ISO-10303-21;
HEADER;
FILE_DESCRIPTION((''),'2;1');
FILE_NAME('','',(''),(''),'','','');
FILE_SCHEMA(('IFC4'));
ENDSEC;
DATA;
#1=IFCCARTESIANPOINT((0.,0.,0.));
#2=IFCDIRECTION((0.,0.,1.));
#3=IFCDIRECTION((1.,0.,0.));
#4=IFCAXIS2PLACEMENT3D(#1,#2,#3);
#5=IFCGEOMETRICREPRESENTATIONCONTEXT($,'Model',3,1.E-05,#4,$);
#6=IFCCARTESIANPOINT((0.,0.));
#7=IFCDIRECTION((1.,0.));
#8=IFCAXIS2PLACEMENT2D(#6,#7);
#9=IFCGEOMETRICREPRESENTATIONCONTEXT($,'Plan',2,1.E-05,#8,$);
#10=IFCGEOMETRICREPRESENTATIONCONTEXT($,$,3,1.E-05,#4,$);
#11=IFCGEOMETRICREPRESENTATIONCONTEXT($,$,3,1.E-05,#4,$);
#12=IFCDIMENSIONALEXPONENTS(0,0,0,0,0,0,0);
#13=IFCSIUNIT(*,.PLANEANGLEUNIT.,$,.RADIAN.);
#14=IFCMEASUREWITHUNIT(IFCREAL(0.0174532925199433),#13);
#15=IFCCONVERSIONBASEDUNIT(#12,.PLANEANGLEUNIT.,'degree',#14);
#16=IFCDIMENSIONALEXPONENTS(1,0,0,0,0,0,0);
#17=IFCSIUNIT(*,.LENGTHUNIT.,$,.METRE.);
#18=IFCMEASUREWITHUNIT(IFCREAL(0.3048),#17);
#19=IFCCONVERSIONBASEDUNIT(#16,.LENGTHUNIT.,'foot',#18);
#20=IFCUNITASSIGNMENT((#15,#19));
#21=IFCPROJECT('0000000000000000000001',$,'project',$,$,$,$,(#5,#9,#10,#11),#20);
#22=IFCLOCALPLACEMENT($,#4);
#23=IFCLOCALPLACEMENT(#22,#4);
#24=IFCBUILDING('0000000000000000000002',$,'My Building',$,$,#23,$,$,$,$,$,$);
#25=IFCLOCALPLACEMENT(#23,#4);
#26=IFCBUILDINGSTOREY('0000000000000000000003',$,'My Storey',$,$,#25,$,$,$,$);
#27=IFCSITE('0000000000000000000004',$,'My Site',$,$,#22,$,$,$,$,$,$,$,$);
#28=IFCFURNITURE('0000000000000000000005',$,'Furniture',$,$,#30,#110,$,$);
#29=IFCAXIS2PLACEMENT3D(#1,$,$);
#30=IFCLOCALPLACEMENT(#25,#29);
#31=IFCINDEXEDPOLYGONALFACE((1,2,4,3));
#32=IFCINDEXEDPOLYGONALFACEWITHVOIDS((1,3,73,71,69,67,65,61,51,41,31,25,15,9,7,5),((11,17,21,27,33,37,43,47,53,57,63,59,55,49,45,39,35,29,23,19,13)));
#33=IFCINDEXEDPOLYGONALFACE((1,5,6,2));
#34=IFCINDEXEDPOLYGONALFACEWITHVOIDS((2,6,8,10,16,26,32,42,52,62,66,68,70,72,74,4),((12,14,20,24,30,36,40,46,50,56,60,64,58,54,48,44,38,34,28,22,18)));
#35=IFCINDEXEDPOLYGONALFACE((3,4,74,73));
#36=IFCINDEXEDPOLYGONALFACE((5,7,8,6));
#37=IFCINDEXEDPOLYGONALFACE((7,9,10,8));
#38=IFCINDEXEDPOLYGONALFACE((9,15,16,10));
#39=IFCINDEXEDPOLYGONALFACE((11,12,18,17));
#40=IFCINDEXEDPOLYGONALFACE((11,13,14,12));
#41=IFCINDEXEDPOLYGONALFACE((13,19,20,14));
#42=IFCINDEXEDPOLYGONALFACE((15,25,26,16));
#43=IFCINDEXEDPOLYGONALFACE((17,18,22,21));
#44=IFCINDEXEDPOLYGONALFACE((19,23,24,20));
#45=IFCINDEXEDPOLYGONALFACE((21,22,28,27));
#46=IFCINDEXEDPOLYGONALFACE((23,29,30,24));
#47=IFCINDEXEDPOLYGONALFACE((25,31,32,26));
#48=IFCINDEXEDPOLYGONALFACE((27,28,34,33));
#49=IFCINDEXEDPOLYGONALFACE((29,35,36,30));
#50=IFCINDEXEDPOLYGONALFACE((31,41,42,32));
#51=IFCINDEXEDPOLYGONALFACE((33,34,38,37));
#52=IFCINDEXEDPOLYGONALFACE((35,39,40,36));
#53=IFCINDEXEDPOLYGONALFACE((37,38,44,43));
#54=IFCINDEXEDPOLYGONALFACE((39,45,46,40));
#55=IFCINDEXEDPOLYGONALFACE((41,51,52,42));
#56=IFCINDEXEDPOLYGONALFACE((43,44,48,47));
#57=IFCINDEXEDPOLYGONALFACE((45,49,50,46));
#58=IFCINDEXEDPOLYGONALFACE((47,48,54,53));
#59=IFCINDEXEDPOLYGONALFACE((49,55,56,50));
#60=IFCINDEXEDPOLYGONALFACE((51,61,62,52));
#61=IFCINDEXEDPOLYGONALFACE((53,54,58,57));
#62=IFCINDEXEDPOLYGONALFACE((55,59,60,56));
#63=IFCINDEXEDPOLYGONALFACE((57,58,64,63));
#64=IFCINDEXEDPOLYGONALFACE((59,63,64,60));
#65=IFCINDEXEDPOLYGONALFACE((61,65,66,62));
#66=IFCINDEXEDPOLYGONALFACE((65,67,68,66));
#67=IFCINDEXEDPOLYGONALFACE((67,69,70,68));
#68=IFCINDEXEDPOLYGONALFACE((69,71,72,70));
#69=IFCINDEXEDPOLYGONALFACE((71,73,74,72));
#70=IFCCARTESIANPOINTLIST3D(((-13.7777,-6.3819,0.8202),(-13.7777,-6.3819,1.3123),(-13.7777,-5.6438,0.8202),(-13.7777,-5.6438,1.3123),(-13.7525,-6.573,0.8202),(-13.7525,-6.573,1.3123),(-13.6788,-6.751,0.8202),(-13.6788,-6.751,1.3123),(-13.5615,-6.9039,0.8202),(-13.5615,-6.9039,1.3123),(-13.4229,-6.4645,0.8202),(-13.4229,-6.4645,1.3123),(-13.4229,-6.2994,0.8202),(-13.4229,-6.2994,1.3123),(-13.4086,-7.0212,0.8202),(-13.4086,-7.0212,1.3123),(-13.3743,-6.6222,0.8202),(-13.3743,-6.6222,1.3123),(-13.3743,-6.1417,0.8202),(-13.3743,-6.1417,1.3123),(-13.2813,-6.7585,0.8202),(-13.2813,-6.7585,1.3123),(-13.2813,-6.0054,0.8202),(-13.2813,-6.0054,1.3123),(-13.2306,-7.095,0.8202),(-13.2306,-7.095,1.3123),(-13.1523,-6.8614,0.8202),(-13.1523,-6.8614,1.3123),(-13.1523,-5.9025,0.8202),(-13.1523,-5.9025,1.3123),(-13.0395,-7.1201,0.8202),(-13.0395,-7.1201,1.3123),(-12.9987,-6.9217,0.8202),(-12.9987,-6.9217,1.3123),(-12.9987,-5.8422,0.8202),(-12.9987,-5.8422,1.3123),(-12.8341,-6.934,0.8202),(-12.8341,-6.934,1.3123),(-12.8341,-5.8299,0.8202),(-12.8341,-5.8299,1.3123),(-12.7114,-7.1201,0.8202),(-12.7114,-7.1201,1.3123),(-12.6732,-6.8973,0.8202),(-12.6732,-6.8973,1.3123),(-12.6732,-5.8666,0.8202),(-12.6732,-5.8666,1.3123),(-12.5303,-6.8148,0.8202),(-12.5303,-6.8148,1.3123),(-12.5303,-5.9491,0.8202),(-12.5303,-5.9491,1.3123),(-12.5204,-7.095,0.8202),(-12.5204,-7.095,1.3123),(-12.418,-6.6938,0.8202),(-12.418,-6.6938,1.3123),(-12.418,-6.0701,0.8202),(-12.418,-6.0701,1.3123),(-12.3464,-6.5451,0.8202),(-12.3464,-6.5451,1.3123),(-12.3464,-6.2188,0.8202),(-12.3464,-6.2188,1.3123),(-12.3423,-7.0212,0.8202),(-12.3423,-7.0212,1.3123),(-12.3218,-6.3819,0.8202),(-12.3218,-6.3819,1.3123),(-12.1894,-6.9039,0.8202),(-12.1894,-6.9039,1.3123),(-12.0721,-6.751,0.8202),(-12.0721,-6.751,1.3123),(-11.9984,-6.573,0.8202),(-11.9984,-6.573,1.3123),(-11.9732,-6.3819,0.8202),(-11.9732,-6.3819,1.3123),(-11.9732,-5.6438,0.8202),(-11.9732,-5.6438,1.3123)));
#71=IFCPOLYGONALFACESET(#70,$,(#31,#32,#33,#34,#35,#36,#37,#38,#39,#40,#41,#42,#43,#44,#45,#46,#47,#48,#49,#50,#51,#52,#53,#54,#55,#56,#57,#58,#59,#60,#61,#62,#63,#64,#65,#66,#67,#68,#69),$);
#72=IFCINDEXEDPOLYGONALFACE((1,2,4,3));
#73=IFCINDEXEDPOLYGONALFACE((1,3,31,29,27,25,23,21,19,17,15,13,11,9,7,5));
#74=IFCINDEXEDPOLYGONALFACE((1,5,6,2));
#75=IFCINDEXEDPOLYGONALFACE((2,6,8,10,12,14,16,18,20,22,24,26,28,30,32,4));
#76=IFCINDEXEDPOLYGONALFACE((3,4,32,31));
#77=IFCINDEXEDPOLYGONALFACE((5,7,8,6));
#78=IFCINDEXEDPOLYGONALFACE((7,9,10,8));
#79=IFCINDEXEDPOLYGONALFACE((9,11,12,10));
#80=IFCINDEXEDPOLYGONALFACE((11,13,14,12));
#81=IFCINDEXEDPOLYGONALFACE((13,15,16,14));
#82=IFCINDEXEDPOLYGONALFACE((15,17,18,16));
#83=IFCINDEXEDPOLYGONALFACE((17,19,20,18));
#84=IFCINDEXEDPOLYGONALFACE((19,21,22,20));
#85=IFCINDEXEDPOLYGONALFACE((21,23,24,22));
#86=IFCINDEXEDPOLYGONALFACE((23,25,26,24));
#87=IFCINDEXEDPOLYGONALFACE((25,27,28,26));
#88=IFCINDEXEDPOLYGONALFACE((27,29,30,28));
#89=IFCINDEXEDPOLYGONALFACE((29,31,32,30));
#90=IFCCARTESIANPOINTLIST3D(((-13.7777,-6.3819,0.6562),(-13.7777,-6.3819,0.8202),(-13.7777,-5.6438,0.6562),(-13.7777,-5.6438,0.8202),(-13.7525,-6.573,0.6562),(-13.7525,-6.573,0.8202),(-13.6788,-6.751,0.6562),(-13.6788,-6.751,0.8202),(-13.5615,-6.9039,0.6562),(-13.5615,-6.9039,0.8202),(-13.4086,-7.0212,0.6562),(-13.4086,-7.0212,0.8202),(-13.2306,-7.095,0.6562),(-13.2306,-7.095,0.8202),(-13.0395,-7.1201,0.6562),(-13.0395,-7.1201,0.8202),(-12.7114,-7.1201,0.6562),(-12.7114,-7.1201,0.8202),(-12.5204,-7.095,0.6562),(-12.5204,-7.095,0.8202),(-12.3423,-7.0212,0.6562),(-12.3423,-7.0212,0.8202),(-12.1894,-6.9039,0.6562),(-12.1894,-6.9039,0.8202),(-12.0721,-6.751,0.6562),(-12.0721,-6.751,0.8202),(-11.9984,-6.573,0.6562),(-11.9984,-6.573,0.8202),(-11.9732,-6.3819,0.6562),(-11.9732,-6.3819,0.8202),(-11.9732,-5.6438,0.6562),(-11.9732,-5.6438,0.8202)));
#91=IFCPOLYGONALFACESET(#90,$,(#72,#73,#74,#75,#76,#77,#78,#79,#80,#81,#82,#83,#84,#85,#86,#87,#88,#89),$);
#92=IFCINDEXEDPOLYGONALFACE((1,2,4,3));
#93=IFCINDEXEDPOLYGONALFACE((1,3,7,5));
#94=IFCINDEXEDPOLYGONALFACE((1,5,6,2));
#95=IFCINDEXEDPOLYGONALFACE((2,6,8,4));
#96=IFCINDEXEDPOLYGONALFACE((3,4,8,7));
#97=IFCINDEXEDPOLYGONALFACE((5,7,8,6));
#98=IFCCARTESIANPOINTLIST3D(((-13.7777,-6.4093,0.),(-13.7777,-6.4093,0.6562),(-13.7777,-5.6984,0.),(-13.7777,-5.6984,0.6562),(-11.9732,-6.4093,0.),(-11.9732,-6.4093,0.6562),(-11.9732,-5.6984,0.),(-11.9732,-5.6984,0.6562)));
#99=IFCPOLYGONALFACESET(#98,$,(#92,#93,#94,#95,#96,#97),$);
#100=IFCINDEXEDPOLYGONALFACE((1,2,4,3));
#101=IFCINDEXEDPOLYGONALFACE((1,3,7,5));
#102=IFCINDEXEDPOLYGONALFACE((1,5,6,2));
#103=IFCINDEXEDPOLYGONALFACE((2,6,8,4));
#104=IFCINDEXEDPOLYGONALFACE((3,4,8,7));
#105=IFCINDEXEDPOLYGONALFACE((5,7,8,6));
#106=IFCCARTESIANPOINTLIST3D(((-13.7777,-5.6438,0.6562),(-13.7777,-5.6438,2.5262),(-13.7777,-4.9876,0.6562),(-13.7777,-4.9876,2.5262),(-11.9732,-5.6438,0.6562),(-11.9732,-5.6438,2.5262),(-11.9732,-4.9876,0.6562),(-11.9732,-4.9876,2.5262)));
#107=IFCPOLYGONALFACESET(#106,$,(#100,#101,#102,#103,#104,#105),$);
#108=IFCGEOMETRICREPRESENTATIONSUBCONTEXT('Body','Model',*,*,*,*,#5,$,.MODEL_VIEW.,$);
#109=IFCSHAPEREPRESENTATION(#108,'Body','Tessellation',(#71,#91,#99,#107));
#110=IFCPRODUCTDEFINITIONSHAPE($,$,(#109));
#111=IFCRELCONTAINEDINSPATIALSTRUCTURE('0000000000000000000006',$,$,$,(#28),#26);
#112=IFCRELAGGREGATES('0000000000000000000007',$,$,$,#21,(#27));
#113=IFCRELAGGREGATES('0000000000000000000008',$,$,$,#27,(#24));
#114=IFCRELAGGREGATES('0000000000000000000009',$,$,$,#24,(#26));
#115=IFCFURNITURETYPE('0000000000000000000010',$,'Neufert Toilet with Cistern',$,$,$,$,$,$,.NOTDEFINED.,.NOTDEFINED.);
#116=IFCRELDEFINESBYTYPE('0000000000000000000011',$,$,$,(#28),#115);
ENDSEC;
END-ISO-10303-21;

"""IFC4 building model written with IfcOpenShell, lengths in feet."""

from ifc_helpers import new_model, entity, si_unit, converted_unit, frame, frame_2d, origin_with_axes, origin_2d_with_axis, place, context, subcontext, project, spatial, line, arc, indexed_curve, circle_curve, outline, extrude, source, transform, mapped, type_object, type_shapes, element, save


model = new_model("IFC4")

# Units and contexts
model_context = context("Model", 3, precision=1e-05, world=origin_with_axes())
plan_context = context("Plan", 2, precision=1e-05, world=origin_2d_with_axis())
context_of_model_1 = context(None, 3, precision=1e-05, world=origin_with_axes())
context_of_model_2 = context(None, 3, precision=1e-05, world=origin_with_axes())
body_context = subcontext(model_context, "Body", "Model", "MODEL_VIEW")
ifc_project = project(units=[converted_unit("PLANEANGLEUNIT", "degree", entity("IfcReal", 0.0174532925199433), si_unit("PLANEANGLEUNIT", "RADIAN"), dimensions=[0, 0, 0, 0, 0, 0, 0]), converted_unit("LENGTHUNIT", "foot", entity("IfcReal", 0.3048), si_unit("LENGTHUNIT", "METRE"), dimensions=[1, 0, 0, 0, 0, 0, 0])], contexts=[model_context, plan_context, context_of_model_1, context_of_model_2])

# Site, building, storey
site_placement = place(None, origin_with_axes())
site = spatial("IfcSite", under=ifc_project, at=site_placement, Name="My Site")
building_placement = place(site_placement, origin_with_axes())
building = spatial("IfcBuilding", under=site, at=building_placement, Name="My Building")
storey_placement = place(building_placement, origin_with_axes())
storey = spatial("IfcBuildingStorey", under=building, at=storey_placement, Name="My Storey")

# Furniture
furniture_type = type_object("IfcFurnitureType", Name="Neufert Toilet with Cistern", AssemblyPlace="NOTDEFINED", PredefinedType="NOTDEFINED")
shared_shape_1 = source(origin_with_axes(), body_context, "Body", "SweptSolid", [
    extrude(outline(indexed_curve([(-0.9022, -0.6562), (0.9022, -0.6562), (0.9022, -1.3944), (0.686, -1.9163), (0.164, -2.1325), (-0.164, -2.1325), (-0.686, -1.9163), (-0.9022, -1.3944)], segments=[line(1, 2), line(2, 3), arc(3, 4, 5), line(5, 6), arc(6, 7, 8), line(1, 8)]), holes=[circle_curve(frame_2d((0.0, -1.3944)), 0.5536)]), frame((0.0, 0.0, 0.8202), z_axis=(0.0, 0.0, 1.0), x_axis=(1.0, 0.0, 0.0)), (0.0, 0.0, 1.0), 0.4921),
    extrude(outline(indexed_curve([(-0.9022, -0.6562), (0.9022, -0.6562), (0.9022, -1.3944), (0.686, -1.9163), (0.164, -2.1325), (-0.164, -2.1325), (-0.686, -1.9163), (-0.9022, -1.3944)], segments=[line(1, 2), line(2, 3), arc(3, 4, 5), line(5, 6), arc(6, 7, 8), line(1, 8)])), frame((0.0, 0.0, 0.6562), z_axis=(0.0, 0.0, 1.0), x_axis=(1.0, 0.0, 0.0)), (0.0, 0.0, 1.0), 0.164),
    extrude(outline(indexed_curve([(-0.9022, -0.7108), (0.9022, -0.7108), (0.9022, -1.4217), (-0.9022, -1.4217)], segments=[line(1, 2), line(2, 3), line(3, 4), line(4, 1)])), origin_with_axes(), (0.0, 0.0, 1.0), 0.6562),
    extrude(outline(indexed_curve([(-0.9022, 0.0), (0.9022, 0.0), (0.9022, -0.6562), (-0.9022, -0.6562)], segments=[line(1, 2), line(2, 3), line(3, 4), line(4, 1)])), frame((0.0, 0.0, 0.6562), z_axis=(0.0, 0.0, 1.0), x_axis=(1.0, 0.0, 0.0)), (0.0, 0.0, 1.0), 1.8701),
])
type_shapes(furniture_type, [shared_shape_1])
furniture_placement = place(storey_placement, frame((-12.8755, -4.9876, 0.0), z_axis=(0.0, 0.0, 1.0), x_axis=(1.0, 0.0, 0.0)))
element("IfcFurniture", 1, at=furniture_placement, inside=storey, type_object=furniture_type, Name="Furniture", context=body_context, shape_type="MappedRepresentation", body=[
    mapped(shared_shape_1, transform((0.0, 0.0, 0.0), x_axis=(1.0, 0.0, 0.0), y_axis=(0.0, 1.0, 0.0), z_axis=(0.0, 0.0, 1.0), scale=1.0)),
])

save(model, "model.ifc")
